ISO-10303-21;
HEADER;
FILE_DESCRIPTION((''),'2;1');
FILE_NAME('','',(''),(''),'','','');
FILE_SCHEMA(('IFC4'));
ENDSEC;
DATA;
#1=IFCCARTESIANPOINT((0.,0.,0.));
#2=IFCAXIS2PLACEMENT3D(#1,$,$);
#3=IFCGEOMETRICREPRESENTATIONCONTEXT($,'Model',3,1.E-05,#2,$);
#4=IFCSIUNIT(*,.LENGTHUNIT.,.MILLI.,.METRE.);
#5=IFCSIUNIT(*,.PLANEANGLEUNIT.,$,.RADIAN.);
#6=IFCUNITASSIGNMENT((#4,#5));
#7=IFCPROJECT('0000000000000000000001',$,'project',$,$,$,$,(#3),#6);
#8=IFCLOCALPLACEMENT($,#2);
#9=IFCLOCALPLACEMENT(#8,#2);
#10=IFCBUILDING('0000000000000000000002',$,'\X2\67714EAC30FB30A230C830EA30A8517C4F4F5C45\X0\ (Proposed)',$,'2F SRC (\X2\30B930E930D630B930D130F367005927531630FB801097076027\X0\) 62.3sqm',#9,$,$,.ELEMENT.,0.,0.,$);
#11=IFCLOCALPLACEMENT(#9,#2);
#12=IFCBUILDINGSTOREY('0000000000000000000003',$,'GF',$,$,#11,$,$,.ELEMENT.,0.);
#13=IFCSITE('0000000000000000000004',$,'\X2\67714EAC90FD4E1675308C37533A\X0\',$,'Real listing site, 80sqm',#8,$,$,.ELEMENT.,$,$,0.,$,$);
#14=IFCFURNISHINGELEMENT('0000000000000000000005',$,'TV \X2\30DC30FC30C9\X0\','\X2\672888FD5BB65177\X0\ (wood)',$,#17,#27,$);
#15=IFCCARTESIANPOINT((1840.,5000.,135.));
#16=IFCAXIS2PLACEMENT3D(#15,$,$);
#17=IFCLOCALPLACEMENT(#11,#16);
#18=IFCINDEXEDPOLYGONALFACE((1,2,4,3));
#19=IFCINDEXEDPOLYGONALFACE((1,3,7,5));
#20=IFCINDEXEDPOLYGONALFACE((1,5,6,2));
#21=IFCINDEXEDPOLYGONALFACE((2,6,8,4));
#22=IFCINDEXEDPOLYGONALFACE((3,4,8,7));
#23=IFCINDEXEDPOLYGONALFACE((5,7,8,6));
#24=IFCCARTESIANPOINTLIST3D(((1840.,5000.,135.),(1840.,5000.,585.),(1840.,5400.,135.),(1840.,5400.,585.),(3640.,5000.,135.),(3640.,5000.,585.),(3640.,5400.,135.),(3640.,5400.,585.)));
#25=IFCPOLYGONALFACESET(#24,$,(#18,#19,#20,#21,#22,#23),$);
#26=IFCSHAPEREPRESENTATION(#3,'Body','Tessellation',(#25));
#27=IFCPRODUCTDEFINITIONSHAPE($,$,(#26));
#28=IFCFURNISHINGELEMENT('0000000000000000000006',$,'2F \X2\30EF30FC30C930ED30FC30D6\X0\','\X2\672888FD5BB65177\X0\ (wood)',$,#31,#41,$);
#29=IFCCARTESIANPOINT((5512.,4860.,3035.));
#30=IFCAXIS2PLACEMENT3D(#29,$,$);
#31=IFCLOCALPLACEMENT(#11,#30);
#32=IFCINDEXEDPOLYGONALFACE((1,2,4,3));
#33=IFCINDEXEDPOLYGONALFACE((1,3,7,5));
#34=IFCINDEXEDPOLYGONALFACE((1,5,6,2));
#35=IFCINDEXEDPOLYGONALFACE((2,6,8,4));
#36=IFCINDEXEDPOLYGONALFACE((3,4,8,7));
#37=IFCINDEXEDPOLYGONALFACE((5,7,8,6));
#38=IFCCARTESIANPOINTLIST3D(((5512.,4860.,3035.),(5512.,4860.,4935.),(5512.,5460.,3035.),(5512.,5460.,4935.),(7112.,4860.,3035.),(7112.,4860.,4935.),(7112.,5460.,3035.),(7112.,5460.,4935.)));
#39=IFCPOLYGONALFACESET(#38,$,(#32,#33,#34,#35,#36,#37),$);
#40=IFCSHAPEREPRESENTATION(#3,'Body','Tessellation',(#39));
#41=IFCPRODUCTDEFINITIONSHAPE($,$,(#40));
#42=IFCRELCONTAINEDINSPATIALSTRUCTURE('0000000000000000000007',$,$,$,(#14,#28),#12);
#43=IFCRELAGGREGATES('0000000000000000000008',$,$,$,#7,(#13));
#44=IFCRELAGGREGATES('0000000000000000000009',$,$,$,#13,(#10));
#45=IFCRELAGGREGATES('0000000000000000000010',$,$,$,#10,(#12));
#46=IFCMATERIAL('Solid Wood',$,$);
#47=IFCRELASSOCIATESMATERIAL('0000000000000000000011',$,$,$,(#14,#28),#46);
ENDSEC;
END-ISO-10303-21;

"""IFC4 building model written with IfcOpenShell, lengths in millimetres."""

from ifc_helpers import new_model, si_unit, frame, frame_2d, origin, place, context, project, spatial, rectangle, extrude, material, element, save


model = new_model("IFC4")

# Units and contexts
model_context = context("Model", 3, precision=1e-05, world=origin())
ifc_project = project(units=[si_unit("LENGTHUNIT", "METRE", prefix="MILLI"), si_unit("PLANEANGLEUNIT", "RADIAN")], contexts=[model_context])

# Site, building, storey
site_placement = place(None, origin())
site = spatial("IfcSite", under=ifc_project, at=site_placement, Name="東京都世田谷区", ObjectType="Real listing site, 80sqm", CompositionType="ELEMENT", RefElevation=0.0)
building_placement = place(site_placement, origin())
building = spatial("IfcBuilding", under=site, at=building_placement, Name="東京・アトリエ兼住居 (Proposed)", ObjectType="2F SRC (スラブスパン最大化・耐震性) 62.3sqm", CompositionType="ELEMENT", ElevationOfRefHeight=0.0, ElevationOfTerrain=0.0)
storey_placement = place(building_placement, origin())
storey = spatial("IfcBuildingStorey", under=building, at=storey_placement, Name="GF", CompositionType="ELEMENT", Elevation=0.0)

# Shared definitions
ifc_material_1 = material(Name="Solid Wood")

# Furnishing elements
furnishing_1_placement = place(storey_placement, frame((1840.0, 5000.0, 135.0)))
element("IfcFurnishingElement", 1, at=furnishing_1_placement, inside=storey, material=ifc_material_1, Name="TV ボード", Description="木製家具 (wood)", context=model_context, shape_type="SweptSolid", body=[
    extrude(rectangle(XDim=1800.0, YDim=400.0, at=frame_2d((900.0, 200.0))), frame((1840.0, 5000.0, 135.0)), (0.0, 0.0, 1.0), 450.0),
])
furnishing_2_placement = place(storey_placement, frame((5512.0, 4860.0, 3035.0)))
element("IfcFurnishingElement", 2, at=furnishing_2_placement, inside=storey, material=ifc_material_1, Name="2F ワードローブ", Description="木製家具 (wood)", context=model_context, shape_type="SweptSolid", body=[
    extrude(rectangle(XDim=1600.0, YDim=600.0, at=frame_2d((800.0, 300.0))), frame((5512.0, 4860.0, 3035.0)), (0.0, 0.0, 1.0), 1900.0),
])

save(model, "model.ifc")
